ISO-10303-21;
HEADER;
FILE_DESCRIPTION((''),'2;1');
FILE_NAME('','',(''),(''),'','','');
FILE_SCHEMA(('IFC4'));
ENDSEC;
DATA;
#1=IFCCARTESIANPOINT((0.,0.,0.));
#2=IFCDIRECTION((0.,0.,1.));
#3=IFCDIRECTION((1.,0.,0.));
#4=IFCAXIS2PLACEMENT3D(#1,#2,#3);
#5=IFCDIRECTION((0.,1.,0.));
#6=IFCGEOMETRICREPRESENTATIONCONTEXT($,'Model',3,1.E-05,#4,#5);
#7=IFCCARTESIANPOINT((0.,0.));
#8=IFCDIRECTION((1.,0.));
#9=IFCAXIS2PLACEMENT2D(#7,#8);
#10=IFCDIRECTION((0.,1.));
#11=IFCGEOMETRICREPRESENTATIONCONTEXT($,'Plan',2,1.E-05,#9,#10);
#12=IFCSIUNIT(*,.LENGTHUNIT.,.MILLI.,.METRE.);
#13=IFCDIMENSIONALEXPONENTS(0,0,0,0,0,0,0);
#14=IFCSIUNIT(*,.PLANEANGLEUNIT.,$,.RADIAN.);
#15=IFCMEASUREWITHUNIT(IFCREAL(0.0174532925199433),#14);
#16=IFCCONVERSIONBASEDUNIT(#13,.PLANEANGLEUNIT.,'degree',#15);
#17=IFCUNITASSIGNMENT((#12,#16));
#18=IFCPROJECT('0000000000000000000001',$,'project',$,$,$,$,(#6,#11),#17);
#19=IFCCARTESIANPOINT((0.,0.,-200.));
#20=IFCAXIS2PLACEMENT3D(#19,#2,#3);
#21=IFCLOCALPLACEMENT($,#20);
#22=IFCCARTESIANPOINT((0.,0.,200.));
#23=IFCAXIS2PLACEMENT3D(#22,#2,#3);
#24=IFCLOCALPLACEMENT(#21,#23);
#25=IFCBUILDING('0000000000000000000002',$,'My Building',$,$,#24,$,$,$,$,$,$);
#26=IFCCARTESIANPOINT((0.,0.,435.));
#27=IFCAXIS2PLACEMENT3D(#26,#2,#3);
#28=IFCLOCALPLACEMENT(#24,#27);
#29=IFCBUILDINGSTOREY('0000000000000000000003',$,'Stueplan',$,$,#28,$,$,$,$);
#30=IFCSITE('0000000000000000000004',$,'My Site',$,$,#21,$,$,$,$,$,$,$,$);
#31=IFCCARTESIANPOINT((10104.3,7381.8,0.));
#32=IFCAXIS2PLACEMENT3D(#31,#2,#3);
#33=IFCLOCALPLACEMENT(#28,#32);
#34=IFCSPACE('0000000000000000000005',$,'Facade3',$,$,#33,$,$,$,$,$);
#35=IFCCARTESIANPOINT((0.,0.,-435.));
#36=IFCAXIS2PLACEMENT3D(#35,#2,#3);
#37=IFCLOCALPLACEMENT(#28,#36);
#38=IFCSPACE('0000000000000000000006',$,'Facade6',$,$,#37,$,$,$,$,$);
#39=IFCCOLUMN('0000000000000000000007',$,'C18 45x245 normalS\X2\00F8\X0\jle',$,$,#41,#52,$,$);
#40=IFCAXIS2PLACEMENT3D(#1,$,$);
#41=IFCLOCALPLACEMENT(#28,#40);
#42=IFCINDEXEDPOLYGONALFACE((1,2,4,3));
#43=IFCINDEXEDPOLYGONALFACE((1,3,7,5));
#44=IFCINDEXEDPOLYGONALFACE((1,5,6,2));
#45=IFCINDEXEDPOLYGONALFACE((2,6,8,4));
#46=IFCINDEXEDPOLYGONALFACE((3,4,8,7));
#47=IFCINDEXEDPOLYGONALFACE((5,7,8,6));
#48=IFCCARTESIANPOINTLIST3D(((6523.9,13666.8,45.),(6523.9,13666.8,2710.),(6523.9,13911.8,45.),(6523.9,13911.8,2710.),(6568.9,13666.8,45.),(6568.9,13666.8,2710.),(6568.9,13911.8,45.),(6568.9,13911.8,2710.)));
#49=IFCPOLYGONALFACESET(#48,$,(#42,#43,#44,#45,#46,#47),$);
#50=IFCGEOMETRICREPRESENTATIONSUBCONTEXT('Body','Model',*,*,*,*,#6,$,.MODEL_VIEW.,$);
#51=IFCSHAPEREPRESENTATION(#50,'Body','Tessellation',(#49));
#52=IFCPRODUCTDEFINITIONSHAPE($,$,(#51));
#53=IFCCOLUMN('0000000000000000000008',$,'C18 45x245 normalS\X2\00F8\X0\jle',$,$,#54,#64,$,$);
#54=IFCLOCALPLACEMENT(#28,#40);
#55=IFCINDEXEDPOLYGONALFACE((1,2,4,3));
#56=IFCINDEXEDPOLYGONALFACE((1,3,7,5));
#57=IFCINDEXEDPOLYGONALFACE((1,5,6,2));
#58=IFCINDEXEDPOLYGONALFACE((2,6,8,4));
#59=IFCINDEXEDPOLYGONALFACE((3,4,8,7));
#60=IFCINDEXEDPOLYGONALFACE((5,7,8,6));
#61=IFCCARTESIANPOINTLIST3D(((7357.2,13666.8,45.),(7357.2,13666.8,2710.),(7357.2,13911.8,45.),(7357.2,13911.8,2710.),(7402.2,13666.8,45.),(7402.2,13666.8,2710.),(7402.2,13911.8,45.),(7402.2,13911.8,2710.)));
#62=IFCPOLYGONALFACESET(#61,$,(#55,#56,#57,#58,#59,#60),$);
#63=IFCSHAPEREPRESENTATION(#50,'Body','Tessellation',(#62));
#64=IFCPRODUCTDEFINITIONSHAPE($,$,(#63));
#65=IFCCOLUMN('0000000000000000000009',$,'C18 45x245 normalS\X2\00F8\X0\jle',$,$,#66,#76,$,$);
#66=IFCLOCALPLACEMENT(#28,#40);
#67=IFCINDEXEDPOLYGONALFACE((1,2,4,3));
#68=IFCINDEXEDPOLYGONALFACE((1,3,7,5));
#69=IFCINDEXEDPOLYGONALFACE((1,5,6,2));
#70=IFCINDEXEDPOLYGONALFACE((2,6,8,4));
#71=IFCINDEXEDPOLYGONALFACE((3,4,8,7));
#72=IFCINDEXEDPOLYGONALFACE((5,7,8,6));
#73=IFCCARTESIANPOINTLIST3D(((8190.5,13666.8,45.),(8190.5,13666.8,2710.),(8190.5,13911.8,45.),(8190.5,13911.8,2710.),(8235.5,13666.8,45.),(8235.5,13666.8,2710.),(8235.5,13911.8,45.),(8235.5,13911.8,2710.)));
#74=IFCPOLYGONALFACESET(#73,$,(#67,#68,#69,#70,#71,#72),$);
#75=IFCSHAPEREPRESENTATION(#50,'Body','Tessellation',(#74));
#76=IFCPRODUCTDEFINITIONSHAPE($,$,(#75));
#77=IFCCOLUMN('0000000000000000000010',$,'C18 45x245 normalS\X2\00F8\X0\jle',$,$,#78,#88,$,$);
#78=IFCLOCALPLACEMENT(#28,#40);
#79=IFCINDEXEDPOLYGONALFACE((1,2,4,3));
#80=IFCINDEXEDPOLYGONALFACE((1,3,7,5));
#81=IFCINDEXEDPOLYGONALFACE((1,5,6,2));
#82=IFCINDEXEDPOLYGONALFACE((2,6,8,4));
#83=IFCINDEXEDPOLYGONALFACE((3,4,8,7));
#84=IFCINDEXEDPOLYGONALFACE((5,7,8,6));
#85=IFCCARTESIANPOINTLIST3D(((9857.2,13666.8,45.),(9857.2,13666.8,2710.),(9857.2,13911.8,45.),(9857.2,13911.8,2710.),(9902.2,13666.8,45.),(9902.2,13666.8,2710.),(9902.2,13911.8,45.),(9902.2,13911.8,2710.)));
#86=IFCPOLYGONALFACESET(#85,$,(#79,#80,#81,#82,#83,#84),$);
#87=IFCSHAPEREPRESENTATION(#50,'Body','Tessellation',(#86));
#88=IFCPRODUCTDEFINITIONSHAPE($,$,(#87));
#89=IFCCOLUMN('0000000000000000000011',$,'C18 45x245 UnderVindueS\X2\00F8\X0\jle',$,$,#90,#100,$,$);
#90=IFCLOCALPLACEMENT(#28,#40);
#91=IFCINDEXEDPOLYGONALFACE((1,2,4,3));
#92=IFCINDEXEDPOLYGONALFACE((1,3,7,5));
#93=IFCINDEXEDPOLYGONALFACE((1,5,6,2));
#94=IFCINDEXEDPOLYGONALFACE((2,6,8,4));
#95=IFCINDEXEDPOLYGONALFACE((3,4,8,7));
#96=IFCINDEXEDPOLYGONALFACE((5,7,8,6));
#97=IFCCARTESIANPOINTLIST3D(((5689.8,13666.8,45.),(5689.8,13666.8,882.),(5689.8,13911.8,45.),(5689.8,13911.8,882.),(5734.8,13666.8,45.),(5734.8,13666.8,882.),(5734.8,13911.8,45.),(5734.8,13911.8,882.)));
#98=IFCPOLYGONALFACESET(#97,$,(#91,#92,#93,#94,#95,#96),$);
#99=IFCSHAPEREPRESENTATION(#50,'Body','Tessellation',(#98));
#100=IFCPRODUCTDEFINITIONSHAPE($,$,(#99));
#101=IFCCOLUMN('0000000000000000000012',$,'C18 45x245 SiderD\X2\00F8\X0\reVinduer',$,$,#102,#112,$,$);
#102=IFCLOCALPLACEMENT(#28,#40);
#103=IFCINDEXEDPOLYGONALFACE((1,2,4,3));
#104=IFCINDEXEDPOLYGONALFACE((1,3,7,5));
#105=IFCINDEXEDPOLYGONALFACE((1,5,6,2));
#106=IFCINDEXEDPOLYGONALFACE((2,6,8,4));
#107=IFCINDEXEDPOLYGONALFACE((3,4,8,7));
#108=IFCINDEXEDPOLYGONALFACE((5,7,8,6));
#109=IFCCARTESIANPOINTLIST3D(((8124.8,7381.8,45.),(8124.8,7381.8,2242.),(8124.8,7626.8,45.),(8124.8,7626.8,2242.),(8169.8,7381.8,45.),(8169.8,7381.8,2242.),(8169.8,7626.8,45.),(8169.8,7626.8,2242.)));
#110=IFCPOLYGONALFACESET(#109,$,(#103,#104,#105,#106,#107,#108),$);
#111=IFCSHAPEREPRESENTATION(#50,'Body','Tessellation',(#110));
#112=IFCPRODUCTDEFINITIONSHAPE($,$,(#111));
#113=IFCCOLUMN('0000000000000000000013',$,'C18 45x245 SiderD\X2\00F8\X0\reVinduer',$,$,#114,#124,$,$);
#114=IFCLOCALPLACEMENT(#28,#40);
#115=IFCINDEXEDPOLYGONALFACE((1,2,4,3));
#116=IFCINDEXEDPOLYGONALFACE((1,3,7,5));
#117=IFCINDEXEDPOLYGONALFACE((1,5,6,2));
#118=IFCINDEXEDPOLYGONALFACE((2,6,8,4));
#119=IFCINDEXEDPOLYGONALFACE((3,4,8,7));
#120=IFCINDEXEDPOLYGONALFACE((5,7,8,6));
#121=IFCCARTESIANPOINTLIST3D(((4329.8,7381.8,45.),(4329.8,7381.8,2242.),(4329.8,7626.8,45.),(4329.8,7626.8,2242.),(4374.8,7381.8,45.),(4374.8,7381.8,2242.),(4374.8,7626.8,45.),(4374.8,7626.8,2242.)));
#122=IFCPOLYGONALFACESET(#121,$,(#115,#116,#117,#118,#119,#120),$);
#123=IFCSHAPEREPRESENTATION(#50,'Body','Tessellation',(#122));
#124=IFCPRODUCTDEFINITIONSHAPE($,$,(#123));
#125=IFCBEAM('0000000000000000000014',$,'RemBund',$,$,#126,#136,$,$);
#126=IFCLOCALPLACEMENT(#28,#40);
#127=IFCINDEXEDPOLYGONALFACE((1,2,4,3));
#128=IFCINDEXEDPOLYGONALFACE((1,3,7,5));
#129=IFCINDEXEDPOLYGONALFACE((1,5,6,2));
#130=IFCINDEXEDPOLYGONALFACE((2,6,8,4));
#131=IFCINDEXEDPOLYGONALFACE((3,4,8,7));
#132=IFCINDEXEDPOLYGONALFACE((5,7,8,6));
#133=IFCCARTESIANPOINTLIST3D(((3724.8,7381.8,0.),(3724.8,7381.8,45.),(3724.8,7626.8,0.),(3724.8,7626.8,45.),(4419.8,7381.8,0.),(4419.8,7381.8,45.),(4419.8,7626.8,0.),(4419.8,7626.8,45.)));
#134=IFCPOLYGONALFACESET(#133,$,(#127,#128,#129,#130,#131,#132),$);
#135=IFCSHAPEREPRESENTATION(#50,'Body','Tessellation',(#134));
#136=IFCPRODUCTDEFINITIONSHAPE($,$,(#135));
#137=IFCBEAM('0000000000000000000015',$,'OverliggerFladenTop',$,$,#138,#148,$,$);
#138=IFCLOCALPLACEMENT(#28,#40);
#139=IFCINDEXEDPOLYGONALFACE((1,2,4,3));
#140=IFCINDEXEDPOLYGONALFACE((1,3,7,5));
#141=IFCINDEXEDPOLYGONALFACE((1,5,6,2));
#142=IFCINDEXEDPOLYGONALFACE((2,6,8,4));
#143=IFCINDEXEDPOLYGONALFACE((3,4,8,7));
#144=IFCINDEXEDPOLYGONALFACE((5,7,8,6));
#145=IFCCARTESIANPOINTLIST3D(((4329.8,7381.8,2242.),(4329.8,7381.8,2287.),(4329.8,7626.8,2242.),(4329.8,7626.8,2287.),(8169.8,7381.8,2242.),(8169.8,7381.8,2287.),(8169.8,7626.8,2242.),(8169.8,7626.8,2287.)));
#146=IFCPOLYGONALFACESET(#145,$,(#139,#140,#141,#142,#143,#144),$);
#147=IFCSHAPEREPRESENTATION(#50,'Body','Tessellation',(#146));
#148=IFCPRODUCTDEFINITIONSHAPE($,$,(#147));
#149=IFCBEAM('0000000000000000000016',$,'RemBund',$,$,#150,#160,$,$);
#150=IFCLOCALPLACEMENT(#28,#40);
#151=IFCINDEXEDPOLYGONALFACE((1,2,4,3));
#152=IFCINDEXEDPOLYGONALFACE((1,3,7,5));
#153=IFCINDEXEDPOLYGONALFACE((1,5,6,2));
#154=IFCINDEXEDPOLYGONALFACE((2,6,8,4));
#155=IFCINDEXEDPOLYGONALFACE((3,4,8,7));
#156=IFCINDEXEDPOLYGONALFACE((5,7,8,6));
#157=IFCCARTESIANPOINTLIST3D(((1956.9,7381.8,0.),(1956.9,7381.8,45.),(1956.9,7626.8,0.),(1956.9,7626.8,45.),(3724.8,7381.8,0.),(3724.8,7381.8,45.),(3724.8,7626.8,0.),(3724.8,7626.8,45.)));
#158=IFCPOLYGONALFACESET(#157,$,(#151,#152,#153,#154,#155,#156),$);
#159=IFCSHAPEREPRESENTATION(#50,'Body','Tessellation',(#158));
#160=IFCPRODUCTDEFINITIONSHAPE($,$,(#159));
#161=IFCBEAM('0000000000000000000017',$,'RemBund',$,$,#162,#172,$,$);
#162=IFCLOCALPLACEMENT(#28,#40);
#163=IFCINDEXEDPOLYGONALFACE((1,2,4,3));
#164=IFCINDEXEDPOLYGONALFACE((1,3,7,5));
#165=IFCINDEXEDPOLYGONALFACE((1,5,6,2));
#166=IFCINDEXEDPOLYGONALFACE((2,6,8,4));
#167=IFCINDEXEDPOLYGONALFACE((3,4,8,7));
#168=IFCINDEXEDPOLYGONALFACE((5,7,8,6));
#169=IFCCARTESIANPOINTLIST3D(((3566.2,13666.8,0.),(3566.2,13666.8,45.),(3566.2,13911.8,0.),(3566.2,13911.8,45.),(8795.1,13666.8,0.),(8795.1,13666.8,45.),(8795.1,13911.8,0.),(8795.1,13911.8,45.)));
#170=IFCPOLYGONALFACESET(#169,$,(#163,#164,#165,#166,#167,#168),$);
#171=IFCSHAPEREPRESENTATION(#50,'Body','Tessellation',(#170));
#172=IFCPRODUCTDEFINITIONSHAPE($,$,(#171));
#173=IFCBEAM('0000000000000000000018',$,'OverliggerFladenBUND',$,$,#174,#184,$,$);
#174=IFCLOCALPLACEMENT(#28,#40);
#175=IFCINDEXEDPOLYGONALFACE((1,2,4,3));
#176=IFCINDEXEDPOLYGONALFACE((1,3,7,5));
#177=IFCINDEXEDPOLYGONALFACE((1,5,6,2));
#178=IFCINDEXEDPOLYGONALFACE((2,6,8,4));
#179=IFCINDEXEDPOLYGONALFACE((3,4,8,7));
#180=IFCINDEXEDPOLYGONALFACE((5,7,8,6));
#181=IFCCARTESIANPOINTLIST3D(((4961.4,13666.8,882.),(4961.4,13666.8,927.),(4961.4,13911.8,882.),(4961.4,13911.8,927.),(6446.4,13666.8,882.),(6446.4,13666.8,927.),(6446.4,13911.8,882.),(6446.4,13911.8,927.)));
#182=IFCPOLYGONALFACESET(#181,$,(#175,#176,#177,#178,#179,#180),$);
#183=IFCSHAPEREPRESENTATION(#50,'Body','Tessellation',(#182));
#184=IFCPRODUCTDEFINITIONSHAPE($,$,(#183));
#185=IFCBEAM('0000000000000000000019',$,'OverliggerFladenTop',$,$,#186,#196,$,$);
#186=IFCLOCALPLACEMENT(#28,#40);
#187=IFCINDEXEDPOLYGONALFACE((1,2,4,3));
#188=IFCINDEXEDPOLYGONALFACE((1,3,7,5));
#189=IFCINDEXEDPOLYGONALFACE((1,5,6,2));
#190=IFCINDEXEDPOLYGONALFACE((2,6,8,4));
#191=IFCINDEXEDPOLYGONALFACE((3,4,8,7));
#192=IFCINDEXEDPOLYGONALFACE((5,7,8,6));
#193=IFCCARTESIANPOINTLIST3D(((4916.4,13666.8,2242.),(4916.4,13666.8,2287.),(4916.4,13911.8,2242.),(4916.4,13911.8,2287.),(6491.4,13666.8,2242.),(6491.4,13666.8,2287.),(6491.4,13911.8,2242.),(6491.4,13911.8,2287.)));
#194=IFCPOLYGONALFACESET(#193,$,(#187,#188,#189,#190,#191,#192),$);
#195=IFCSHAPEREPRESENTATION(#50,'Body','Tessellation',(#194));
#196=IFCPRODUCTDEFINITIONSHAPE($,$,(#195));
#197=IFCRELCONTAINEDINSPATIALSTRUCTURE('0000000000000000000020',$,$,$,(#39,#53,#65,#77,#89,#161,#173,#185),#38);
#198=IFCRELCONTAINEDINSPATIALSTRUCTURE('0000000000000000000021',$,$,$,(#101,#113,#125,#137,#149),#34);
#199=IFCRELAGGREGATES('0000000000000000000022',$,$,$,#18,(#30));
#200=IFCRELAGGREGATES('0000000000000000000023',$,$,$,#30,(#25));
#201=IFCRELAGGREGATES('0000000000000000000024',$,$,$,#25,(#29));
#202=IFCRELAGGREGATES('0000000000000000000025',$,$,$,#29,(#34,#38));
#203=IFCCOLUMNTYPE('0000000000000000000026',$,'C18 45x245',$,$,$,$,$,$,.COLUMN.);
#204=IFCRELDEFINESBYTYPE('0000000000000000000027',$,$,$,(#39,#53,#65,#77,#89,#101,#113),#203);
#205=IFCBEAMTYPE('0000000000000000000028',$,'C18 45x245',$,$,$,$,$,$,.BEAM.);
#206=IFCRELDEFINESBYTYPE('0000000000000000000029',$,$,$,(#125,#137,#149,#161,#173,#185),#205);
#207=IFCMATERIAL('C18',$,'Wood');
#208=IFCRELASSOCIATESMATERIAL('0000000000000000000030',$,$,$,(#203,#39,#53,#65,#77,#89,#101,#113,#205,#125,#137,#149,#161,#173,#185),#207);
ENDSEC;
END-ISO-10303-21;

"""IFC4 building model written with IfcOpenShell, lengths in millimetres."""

from ifc_helpers import new_model, entity, si_unit, converted_unit, direction, frame, origin_with_axes, origin_2d_with_axis, place, context, subcontext, project, spatial, rectangle, extrude, material, material_profile, profile_set, profile_usage, type_object, element, save


model = new_model("IFC4")

# Units and contexts
model_context = context("Model", 3, precision=1e-05, world=origin_with_axes(), true_north=direction((0.0, 1.0, 0.0)))
plan_context = context("Plan", 2, precision=1e-05, world=origin_2d_with_axis(), true_north=direction((0.0, 1.0)))
body_context_1 = subcontext(model_context, "Body", "Model", "MODEL_VIEW")
ifc_project = project(units=[si_unit("LENGTHUNIT", "METRE", prefix="MILLI"), converted_unit("PLANEANGLEUNIT", "degree", entity("IfcReal", 0.0174532925199433), si_unit("PLANEANGLEUNIT", "RADIAN"), dimensions=[0, 0, 0, 0, 0, 0, 0])], contexts=[model_context, plan_context])

# Site, building, storey, space
site_placement = place(None, frame((0.0, 0.0, -200.0), z_axis=(0.0, 0.0, 1.0), x_axis=(1.0, 0.0, 0.0)))
site = spatial("IfcSite", under=ifc_project, at=site_placement, Name="My Site")
building_placement = place(site_placement, frame((0.0, 0.0, 200.0), z_axis=(0.0, 0.0, 1.0), x_axis=(1.0, 0.0, 0.0)))
building = spatial("IfcBuilding", under=site, at=building_placement, Name="My Building")
storey_placement = place(building_placement, frame((0.0, 0.0, 435.0), z_axis=(0.0, 0.0, 1.0), x_axis=(1.0, 0.0, 0.0)))
storey = spatial("IfcBuildingStorey", under=building, at=storey_placement, Name="Stueplan")
space_1_placement = place(storey_placement, frame((10104.3, 7381.8, 0.0), z_axis=(0.0, 0.0, 1.0), x_axis=(1.0, 0.0, 0.0)))
space_1 = spatial("IfcSpace", under=storey, at=space_1_placement, Name="Facade3")

# Shared definitions
ifc_material = material(Name="C18", Category="Wood")
ifc_material_profile_1 = material_profile(ifc_material, rectangle(XDim=45.0, YDim=245.0))
ifc_profile_set_1 = profile_set([ifc_material_profile_1], Name="woodStructural")
column_type = type_object("IfcColumnType", Name="C18 45x245", PredefinedType="COLUMN", material=ifc_profile_set_1)

# Shared definitions
space_2_placement = place(storey_placement, frame((0.0, 0.0, -435.0), z_axis=(0.0, 0.0, 1.0), x_axis=(1.0, 0.0, 0.0)))
space_2 = spatial("IfcSpace", under=storey, at=space_2_placement, Name="Facade6")

# Columns
ifc_profile_usage_1 = profile_usage(ifc_profile_set_1, cardinal=9)
column_1_placement = place(space_2_placement, frame((6523.9, 13911.8, 480.0), z_axis=(0.0, 0.0, 1.0), x_axis=(1.0, 0.0, 0.0)))
element("IfcColumn", 1, at=column_1_placement, inside=space_2, type_object=column_type, material=ifc_profile_usage_1, Name="C18 45x245 normalSøjle", context=body_context_1, shape_type="SweptSolid", body=[
    extrude(rectangle(XDim=45.0, YDim=245.0), frame((22.5, -122.5, 0.0), z_axis=(0.0, 0.0, 1.0), x_axis=(1.0, 0.0, 0.0)), (0.0, 0.0, 1.0), 2665.0),
])
ifc_profile_usage_2 = profile_usage(ifc_profile_set_1, cardinal=9)
column_2_placement = place(space_2_placement, frame((7357.2, 13911.8, 480.0), z_axis=(0.0, 0.0, 1.0), x_axis=(1.0, 0.0, 0.0)))
element("IfcColumn", 2, at=column_2_placement, inside=space_2, type_object=column_type, material=ifc_profile_usage_2, Name="C18 45x245 normalSøjle", context=body_context_1, shape_type="SweptSolid", body=[
    extrude(rectangle(XDim=45.0, YDim=245.0), frame((22.5, -122.5, 0.0), z_axis=(0.0, 0.0, 1.0), x_axis=(1.0, 0.0, 0.0)), (0.0, 0.0, 1.0), 2665.0),
])
ifc_profile_usage_3 = profile_usage(ifc_profile_set_1, cardinal=9)
column_3_placement = place(space_2_placement, frame((8190.5, 13911.8, 480.0), z_axis=(0.0, 0.0, 1.0), x_axis=(1.0, 0.0, 0.0)))
element("IfcColumn", 3, at=column_3_placement, inside=space_2, type_object=column_type, material=ifc_profile_usage_3, Name="C18 45x245 normalSøjle", context=body_context_1, shape_type="SweptSolid", body=[
    extrude(rectangle(XDim=45.0, YDim=245.0), frame((22.5, -122.5, 0.0), z_axis=(0.0, 0.0, 1.0), x_axis=(1.0, 0.0, 0.0)), (0.0, 0.0, 1.0), 2665.0),
])
ifc_profile_usage_4 = profile_usage(ifc_profile_set_1, cardinal=9)
column_4_placement = place(space_2_placement, frame((9857.2, 13911.8, 480.0), z_axis=(0.0, 0.0, 1.0), x_axis=(1.0, 0.0, 0.0)))
element("IfcColumn", 4, at=column_4_placement, inside=space_2, type_object=column_type, material=ifc_profile_usage_4, Name="C18 45x245 normalSøjle", context=body_context_1, shape_type="SweptSolid", body=[
    extrude(rectangle(XDim=45.0, YDim=245.0), frame((22.5, -122.5, 0.0), z_axis=(0.0, 0.0, 1.0), x_axis=(1.0, 0.0, 0.0)), (0.0, 0.0, 1.0), 2665.0),
])
ifc_profile_usage_5 = profile_usage(ifc_profile_set_1, cardinal=9)
column_5_placement = place(space_2_placement, frame((5689.8, 13911.8, 480.0), z_axis=(0.0, 0.0, 1.0), x_axis=(1.0, 0.0, 0.0)))
element("IfcColumn", 5, at=column_5_placement, inside=space_2, type_object=column_type, material=ifc_profile_usage_5, Name="C18 45x245 UnderVindueSøjle", context=body_context_1, shape_type="SweptSolid", body=[
    extrude(rectangle(XDim=45.0, YDim=245.0), frame((22.5, -122.5, 0.0), z_axis=(0.0, 0.0, 1.0), x_axis=(1.0, 0.0, 0.0)), (0.0, 0.0, 1.0), 837.0),
])
ifc_profile_usage_6 = profile_usage(ifc_profile_set_1, cardinal=9)
column_6_placement = place(space_1_placement, frame((-1979.6, 245.0, 45.0), z_axis=(0.0, 0.0, 1.0), x_axis=(1.0, 0.0, 0.0)))
element("IfcColumn", 6, at=column_6_placement, inside=space_1, type_object=column_type, material=ifc_profile_usage_6, Name="C18 45x245 SiderDøreVinduer", context=body_context_1, shape_type="SweptSolid", body=[
    extrude(rectangle(XDim=45.0, YDim=245.0), frame((22.5, -122.5, 0.0), z_axis=(0.0, 0.0, 1.0), x_axis=(1.0, 0.0, 0.0)), (0.0, 0.0, 1.0), 2197.0),
])
ifc_profile_usage_7 = profile_usage(ifc_profile_set_1, cardinal=9)
column_7_placement = place(space_1_placement, frame((-5774.6, 245.0, 45.0), z_axis=(0.0, 0.0, 1.0), x_axis=(1.0, 0.0, 0.0)))
element("IfcColumn", 7, at=column_7_placement, inside=space_1, type_object=column_type, material=ifc_profile_usage_7, Name="C18 45x245 SiderDøreVinduer", context=body_context_1, shape_type="SweptSolid", body=[
    extrude(rectangle(XDim=45.0, YDim=245.0), frame((22.5, -122.5, 0.0), z_axis=(0.0, 0.0, 1.0), x_axis=(1.0, 0.0, 0.0)), (0.0, 0.0, 1.0), 2197.0),
])

# Beams
ifc_material_profile_2 = material_profile(ifc_material, rectangle(XDim=45.0, YDim=245.0), Name="concrete")
ifc_profile_set_2 = profile_set([ifc_material_profile_2], Name="woodStructural")
beam_type = type_object("IfcBeamType", Name="C18 45x245", PredefinedType="BEAM", material=ifc_profile_set_2)
ifc_profile_usage_8 = profile_usage(ifc_profile_set_2)
beam_1_placement = place(space_1_placement, frame((-5684.6, 122.5, 22.5), z_axis=(-1.0, 0.0, 0.0), x_axis=(0.0, 0.0, 1.0)))
element("IfcBeam", 8, at=beam_1_placement, inside=space_1, type_object=beam_type, material=ifc_profile_usage_8, Name="RemBund", context=body_context_1, shape_type="SweptSolid", body=[
    extrude(rectangle(XDim=45.0, YDim=245.0), origin_with_axes(), (0.0, 0.0, 1.0), 695.0),
])
ifc_profile_usage_9 = profile_usage(ifc_profile_set_2)
beam_2_placement = place(space_1_placement, frame((-1934.6, 122.5, 2264.5), z_axis=(-1.0, 0.0, 0.0), x_axis=(0.0, 0.0, 1.0)))
element("IfcBeam", 9, at=beam_2_placement, inside=space_1, type_object=beam_type, material=ifc_profile_usage_9, Name="OverliggerFladenTop", context=body_context_1, shape_type="SweptSolid", body=[
    extrude(rectangle(XDim=45.0, YDim=245.0), origin_with_axes(), (0.0, 0.0, 1.0), 3840.0),
])
ifc_profile_usage_10 = profile_usage(ifc_profile_set_2)
beam_3_placement = place(space_1_placement, frame((-6379.6, 122.5, 22.5), z_axis=(-1.0, 0.0, 0.0), x_axis=(0.0, 0.0, 1.0)))
element("IfcBeam", 10, at=beam_3_placement, inside=space_1, type_object=beam_type, material=ifc_profile_usage_10, Name="RemBund", context=body_context_1, shape_type="SweptSolid", body=[
    extrude(rectangle(XDim=45.0, YDim=245.0), origin_with_axes(), (0.0, 0.0, 1.0), 1767.9),
])
ifc_profile_usage_11 = profile_usage(ifc_profile_set_2)
beam_4_placement = place(space_2_placement, frame((8795.1, 13789.3, 457.5), z_axis=(-1.0, 0.0, 0.0), x_axis=(0.0, 0.0, 1.0)))
element("IfcBeam", 11, at=beam_4_placement, inside=space_2, type_object=beam_type, material=ifc_profile_usage_11, Name="RemBund", context=body_context_1, shape_type="SweptSolid", body=[
    extrude(rectangle(XDim=45.0, YDim=245.0), origin_with_axes(), (0.0, 0.0, 1.0), 5228.8),
])
ifc_profile_usage_12 = profile_usage(ifc_profile_set_2)
beam_5_placement = place(space_2_placement, frame((6446.4, 13789.3, 1339.5), z_axis=(-1.0, 0.0, 0.0), x_axis=(0.0, 0.0, 1.0)))
element("IfcBeam", 12, at=beam_5_placement, inside=space_2, type_object=beam_type, material=ifc_profile_usage_12, Name="OverliggerFladenBUND", context=body_context_1, shape_type="SweptSolid", body=[
    extrude(rectangle(XDim=45.0, YDim=245.0), origin_with_axes(), (0.0, 0.0, 1.0), 1485.0),
])
ifc_profile_usage_13 = profile_usage(ifc_profile_set_2)
beam_6_placement = place(space_2_placement, frame((6491.4, 13789.3, 2699.5), z_axis=(-1.0, 0.0, 0.0), x_axis=(0.0, 0.0, 1.0)))
element("IfcBeam", 13, at=beam_6_placement, inside=space_2, type_object=beam_type, material=ifc_profile_usage_13, Name="OverliggerFladenTop", context=body_context_1, shape_type="SweptSolid", body=[
    extrude(rectangle(XDim=45.0, YDim=245.0), origin_with_axes(), (0.0, 0.0, 1.0), 1575.0),
])

save(model, "model.ifc")
